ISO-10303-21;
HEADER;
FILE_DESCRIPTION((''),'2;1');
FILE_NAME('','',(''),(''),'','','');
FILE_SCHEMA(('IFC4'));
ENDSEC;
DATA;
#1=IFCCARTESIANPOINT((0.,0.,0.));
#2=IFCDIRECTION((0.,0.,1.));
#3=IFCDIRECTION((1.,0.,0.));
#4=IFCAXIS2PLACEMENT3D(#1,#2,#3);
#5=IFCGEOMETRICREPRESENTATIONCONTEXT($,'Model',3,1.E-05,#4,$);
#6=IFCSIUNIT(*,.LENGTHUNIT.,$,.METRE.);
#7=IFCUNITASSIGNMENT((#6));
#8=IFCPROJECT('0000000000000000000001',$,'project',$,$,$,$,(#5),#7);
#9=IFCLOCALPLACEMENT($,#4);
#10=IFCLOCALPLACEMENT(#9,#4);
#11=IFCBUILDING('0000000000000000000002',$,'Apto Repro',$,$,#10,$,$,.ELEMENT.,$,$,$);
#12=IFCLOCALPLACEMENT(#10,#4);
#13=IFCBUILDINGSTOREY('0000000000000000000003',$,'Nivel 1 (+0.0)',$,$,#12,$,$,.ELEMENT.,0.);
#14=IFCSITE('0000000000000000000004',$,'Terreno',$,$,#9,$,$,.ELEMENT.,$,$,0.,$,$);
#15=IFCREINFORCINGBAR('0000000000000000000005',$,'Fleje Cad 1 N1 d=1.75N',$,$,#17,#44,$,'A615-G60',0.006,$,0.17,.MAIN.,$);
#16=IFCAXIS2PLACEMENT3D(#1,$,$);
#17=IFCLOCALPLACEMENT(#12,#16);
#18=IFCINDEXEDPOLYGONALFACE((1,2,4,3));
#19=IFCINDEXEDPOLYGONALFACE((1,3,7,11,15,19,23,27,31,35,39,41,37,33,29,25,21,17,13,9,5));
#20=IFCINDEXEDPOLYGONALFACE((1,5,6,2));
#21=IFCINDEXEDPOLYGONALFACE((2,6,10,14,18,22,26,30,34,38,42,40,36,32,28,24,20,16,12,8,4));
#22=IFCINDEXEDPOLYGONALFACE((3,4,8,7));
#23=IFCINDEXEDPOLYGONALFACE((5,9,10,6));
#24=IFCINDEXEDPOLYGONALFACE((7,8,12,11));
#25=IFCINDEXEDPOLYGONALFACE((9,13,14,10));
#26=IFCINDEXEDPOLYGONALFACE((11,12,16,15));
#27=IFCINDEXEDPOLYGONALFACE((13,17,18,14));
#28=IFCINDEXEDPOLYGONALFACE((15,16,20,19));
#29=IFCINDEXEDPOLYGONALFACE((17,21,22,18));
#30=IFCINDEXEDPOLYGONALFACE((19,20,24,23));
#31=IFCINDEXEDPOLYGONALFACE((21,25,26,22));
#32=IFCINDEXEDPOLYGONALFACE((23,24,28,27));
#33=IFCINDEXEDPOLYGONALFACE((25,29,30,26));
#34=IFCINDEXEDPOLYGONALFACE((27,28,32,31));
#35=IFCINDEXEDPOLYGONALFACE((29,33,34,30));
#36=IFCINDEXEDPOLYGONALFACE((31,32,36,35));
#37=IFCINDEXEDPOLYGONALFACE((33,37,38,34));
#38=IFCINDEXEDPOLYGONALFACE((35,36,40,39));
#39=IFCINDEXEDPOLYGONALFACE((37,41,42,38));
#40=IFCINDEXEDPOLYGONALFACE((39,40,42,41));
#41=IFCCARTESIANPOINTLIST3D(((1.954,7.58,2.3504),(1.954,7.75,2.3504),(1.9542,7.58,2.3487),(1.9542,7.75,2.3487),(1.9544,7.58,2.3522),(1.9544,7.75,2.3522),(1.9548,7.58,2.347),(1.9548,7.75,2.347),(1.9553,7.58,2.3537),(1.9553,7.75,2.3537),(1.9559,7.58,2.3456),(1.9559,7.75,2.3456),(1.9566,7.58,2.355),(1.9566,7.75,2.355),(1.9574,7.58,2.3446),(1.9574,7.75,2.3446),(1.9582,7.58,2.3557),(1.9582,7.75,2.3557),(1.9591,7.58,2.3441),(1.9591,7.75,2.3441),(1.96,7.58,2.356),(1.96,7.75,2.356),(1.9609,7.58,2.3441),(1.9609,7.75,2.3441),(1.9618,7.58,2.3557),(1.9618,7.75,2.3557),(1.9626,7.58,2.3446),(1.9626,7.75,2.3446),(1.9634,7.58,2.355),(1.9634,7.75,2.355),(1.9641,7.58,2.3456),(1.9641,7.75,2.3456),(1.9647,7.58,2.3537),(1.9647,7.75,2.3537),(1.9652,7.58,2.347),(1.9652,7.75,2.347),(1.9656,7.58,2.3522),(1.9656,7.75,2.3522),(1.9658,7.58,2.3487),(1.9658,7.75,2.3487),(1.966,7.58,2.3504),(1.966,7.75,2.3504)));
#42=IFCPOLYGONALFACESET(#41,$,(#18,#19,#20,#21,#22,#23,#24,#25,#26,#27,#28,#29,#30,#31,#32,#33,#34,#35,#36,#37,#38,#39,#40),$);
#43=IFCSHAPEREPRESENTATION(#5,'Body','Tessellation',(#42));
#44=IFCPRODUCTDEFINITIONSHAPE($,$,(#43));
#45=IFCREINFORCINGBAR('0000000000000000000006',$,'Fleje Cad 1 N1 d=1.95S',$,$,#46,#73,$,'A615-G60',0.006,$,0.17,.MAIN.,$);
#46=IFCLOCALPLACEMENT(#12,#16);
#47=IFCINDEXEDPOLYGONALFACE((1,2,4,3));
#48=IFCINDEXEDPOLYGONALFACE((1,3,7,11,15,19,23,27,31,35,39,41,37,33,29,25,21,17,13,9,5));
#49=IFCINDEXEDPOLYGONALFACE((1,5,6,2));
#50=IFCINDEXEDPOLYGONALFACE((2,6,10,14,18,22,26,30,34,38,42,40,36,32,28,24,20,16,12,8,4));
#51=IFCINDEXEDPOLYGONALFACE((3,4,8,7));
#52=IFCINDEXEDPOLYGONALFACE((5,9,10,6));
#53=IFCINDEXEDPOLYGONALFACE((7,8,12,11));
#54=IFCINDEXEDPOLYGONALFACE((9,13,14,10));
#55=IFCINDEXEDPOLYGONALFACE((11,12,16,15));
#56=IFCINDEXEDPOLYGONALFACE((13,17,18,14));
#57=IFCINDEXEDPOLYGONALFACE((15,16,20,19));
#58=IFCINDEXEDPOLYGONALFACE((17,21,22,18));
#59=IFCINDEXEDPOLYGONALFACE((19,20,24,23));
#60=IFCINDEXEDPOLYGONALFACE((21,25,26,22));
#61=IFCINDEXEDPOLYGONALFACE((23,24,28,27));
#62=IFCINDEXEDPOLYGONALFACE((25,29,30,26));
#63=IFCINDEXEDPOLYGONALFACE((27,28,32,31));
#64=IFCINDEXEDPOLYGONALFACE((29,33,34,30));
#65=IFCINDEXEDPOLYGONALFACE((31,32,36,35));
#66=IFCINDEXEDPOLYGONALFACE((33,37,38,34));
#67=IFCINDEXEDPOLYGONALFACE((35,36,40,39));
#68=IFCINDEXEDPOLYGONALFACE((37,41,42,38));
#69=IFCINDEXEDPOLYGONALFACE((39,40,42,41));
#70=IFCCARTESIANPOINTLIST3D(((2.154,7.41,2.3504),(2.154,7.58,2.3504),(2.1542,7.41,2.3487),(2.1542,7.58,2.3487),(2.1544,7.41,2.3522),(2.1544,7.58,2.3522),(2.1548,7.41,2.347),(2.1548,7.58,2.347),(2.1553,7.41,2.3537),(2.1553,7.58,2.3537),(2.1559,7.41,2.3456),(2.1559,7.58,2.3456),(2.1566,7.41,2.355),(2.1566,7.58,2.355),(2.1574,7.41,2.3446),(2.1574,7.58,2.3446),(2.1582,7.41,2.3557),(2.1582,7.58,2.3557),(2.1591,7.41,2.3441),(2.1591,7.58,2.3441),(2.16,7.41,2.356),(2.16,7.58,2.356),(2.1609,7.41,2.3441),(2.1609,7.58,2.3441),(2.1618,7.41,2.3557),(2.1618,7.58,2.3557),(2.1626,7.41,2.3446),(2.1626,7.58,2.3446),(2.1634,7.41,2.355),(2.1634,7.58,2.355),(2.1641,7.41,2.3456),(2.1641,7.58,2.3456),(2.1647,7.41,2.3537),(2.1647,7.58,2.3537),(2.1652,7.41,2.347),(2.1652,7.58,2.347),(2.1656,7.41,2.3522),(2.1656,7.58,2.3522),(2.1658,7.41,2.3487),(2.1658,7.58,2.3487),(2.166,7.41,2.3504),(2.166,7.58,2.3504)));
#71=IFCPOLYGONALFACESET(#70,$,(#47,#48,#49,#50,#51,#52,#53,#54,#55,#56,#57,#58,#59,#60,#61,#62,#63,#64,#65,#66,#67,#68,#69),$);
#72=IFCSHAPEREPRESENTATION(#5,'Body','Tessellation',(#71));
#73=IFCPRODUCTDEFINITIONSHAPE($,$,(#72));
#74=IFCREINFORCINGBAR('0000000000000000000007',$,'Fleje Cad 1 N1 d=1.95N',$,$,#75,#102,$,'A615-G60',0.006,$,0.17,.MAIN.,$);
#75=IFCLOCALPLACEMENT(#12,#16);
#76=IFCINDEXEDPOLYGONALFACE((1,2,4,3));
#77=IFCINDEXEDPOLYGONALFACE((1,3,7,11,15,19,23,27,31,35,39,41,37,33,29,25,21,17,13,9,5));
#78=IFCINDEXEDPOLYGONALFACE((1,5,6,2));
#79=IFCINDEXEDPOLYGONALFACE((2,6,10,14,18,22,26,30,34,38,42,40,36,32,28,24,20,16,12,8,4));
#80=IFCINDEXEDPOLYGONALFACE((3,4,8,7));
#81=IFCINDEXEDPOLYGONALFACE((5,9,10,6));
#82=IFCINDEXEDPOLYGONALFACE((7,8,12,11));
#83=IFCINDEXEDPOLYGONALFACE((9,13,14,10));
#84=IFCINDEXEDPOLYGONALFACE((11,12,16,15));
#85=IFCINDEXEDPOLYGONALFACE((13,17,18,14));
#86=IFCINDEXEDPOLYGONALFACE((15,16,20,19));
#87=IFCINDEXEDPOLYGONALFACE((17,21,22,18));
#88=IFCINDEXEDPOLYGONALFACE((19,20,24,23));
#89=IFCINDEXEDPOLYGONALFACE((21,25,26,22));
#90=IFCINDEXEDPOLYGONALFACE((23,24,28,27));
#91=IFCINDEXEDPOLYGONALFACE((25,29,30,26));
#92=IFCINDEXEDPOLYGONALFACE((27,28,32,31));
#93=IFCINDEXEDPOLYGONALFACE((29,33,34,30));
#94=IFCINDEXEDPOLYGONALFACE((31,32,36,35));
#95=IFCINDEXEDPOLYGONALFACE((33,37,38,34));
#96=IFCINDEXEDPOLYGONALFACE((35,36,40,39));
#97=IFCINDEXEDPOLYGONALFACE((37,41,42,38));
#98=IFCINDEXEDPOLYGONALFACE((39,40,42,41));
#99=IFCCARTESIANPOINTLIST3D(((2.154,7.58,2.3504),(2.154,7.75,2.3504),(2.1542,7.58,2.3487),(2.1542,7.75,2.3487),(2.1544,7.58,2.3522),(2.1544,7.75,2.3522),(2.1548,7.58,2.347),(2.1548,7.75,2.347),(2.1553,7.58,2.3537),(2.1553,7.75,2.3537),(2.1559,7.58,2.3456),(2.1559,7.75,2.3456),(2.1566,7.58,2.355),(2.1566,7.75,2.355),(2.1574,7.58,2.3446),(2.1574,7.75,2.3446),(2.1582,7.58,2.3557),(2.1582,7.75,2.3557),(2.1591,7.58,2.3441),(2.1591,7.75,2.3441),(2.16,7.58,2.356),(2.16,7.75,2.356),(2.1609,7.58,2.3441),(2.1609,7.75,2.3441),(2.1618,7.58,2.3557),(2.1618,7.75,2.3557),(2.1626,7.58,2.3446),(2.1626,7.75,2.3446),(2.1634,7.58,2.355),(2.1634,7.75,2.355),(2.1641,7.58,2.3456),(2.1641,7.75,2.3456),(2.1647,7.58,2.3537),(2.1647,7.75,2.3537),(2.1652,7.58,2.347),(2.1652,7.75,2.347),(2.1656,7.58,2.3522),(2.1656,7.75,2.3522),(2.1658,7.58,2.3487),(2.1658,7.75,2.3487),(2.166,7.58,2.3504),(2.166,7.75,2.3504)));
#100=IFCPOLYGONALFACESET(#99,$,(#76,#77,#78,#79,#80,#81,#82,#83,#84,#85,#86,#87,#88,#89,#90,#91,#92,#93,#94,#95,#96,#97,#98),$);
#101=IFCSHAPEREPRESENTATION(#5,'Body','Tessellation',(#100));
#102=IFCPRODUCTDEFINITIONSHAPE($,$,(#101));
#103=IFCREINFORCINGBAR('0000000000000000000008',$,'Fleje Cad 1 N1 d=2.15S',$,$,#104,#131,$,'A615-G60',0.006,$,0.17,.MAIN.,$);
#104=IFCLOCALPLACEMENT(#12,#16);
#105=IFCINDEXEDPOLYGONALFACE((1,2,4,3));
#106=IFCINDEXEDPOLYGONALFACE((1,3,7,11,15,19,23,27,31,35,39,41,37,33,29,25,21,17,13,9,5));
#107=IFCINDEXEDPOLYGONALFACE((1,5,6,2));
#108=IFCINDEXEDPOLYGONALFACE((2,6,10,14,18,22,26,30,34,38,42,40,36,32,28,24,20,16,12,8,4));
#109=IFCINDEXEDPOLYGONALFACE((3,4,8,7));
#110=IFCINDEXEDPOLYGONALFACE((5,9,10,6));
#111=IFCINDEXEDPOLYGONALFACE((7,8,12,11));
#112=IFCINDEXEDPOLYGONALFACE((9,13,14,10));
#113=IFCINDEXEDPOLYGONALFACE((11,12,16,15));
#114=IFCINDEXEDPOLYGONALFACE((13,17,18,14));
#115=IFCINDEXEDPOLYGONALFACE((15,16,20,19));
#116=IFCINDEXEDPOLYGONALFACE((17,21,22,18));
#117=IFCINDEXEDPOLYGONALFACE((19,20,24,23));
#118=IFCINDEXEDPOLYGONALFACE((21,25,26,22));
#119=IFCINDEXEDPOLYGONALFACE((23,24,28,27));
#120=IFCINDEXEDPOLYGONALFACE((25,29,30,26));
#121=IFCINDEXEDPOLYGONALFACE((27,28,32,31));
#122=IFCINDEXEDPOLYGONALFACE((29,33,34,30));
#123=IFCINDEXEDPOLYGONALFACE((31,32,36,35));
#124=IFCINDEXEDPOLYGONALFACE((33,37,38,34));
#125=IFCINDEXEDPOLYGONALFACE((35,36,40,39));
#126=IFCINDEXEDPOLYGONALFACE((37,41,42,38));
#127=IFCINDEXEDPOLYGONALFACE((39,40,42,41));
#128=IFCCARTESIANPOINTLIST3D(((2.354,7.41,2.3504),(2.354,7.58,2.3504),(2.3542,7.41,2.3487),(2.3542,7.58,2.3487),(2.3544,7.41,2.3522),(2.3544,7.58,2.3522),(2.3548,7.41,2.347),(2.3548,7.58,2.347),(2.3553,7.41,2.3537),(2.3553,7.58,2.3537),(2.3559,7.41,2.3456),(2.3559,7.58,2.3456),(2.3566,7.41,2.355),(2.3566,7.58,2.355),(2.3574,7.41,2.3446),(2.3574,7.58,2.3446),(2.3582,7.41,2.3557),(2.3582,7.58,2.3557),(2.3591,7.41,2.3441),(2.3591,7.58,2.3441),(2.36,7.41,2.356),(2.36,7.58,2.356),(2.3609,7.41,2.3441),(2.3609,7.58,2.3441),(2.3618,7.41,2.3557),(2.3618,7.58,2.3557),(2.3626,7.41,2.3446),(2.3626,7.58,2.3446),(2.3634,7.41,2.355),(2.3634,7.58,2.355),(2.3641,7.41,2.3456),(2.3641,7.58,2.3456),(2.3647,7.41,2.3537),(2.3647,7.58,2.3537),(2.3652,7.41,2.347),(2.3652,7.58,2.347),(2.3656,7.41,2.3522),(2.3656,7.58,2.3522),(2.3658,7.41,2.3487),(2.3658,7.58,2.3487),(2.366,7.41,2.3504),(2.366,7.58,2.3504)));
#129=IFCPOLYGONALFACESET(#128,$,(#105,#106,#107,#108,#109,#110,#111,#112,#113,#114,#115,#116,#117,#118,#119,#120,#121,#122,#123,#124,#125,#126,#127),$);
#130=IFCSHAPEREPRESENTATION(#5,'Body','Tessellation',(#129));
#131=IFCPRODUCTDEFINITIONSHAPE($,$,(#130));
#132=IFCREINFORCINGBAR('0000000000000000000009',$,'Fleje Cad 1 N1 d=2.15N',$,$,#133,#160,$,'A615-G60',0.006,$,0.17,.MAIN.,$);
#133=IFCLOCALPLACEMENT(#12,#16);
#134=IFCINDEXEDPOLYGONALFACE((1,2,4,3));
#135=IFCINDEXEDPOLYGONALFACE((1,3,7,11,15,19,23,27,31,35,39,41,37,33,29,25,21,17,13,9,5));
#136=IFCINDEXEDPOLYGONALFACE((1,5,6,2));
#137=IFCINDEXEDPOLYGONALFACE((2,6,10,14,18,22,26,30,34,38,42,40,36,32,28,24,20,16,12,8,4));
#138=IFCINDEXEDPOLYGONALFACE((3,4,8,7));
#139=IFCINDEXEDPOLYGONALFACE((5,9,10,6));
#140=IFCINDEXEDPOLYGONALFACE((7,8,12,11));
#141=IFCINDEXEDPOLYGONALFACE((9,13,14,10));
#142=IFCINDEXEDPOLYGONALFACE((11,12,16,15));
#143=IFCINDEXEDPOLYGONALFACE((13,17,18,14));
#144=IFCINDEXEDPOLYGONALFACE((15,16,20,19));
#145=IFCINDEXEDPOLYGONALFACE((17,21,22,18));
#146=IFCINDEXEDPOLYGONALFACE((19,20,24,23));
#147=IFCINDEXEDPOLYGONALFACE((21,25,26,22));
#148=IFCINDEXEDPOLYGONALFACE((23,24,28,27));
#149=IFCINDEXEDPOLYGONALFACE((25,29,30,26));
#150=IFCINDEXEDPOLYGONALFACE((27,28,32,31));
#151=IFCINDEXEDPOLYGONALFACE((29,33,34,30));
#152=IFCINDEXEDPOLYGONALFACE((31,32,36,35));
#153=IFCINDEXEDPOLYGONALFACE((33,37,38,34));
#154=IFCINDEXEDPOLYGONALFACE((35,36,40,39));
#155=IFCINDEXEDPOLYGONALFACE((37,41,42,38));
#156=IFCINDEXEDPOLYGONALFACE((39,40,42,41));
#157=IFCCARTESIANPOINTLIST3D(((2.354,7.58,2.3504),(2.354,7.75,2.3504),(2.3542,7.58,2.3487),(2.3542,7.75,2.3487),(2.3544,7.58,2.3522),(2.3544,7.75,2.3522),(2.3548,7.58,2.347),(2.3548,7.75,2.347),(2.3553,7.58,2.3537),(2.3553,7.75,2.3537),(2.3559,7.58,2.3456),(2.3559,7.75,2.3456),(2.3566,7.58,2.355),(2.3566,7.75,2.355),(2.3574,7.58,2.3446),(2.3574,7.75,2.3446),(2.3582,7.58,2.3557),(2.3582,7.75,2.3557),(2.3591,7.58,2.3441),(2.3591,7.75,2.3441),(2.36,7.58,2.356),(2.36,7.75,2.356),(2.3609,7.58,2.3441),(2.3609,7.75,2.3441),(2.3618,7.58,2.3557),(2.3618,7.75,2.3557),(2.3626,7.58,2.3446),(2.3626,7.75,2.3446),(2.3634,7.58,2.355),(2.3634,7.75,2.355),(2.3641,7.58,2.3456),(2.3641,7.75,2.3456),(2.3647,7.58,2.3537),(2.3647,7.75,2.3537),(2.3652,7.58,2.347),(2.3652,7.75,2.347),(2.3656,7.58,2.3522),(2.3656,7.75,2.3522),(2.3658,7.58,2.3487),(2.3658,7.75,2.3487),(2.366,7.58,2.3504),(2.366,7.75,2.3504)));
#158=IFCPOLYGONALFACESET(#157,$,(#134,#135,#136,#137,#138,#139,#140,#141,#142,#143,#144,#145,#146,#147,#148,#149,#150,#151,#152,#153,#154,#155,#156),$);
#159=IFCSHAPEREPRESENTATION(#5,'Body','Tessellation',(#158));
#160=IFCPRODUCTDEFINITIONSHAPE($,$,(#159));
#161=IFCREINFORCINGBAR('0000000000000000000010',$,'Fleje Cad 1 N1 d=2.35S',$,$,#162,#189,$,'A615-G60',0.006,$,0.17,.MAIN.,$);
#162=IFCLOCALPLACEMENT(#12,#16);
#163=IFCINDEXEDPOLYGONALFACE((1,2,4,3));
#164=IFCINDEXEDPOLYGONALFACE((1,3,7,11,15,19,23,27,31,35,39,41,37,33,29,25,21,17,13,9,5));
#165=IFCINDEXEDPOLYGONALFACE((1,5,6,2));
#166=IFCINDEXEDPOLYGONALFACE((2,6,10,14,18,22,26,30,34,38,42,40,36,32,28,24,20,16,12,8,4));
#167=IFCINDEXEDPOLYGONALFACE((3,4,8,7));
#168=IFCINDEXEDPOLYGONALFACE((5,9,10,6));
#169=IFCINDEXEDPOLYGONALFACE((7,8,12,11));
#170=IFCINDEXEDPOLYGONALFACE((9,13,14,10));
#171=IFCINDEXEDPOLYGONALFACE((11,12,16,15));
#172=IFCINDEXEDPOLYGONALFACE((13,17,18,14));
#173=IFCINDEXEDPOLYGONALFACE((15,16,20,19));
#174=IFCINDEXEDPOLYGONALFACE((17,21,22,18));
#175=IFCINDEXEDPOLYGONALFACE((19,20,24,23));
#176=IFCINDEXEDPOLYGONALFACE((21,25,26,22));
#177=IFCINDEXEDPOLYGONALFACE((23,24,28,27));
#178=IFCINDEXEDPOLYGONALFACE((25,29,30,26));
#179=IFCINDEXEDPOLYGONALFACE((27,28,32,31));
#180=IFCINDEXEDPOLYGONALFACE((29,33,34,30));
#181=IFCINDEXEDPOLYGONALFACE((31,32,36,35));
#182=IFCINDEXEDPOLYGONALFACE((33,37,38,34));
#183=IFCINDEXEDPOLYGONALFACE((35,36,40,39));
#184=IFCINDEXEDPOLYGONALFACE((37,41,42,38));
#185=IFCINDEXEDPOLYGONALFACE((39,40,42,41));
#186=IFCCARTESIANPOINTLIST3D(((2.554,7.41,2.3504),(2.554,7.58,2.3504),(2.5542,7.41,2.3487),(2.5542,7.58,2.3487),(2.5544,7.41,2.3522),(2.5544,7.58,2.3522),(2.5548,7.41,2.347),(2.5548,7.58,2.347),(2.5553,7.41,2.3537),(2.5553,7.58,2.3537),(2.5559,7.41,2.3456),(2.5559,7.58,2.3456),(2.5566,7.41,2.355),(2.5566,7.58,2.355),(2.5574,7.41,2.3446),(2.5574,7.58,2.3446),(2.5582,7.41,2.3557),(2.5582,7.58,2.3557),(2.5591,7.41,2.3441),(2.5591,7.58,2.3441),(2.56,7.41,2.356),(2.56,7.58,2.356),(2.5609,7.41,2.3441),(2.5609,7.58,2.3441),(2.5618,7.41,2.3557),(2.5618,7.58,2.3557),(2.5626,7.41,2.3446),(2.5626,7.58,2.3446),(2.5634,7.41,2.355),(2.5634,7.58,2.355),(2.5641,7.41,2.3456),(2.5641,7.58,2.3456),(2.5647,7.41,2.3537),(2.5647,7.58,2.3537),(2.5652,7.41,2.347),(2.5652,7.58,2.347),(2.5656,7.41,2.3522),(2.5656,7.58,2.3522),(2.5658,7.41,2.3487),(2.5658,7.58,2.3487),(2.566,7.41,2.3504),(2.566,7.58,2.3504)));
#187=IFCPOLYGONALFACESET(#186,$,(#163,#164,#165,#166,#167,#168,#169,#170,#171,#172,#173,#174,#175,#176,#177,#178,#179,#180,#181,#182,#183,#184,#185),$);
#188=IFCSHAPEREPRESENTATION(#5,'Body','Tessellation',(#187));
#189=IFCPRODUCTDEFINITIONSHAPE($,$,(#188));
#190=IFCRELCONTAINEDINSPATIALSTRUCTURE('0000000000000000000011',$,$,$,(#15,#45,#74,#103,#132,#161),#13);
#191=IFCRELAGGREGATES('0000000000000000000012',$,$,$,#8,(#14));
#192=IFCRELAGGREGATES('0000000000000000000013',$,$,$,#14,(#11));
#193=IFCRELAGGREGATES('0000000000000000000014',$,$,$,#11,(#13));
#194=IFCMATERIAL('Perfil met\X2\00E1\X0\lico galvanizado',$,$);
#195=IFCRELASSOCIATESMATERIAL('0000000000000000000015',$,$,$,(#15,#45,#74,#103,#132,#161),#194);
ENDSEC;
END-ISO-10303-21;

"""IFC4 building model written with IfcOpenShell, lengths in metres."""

from ifc_helpers import new_model, si_unit, frame, origin_with_axes, origin_2d_with_axis, place, context, project, spatial, circle, extrude, material, element, save


model = new_model("IFC4")

# Units and contexts
model_context = context("Model", 3, precision=1e-05, world=origin_with_axes())
ifc_project = project(units=[si_unit("LENGTHUNIT", "METRE")], contexts=[model_context])

# Site, building, storey
site_placement = place(None, origin_with_axes())
site = spatial("IfcSite", under=ifc_project, at=site_placement, Name="Terreno", CompositionType="ELEMENT", RefElevation=0.0)
building_placement = place(site_placement, origin_with_axes())
building = spatial("IfcBuilding", under=site, at=building_placement, Name="Apto Repro", CompositionType="ELEMENT")
storey_placement = place(building_placement, origin_with_axes())
storey = spatial("IfcBuildingStorey", under=building, at=storey_placement, Name="Nivel 1 (+0.0)", CompositionType="ELEMENT", Elevation=0.0)

# Reinforcing bars
ifc_material = material(Name="Perfil metálico galvanizado")
reinforcing_bar_1_placement = place(storey_placement, origin_with_axes())
element("IfcReinforcingBar", 1, at=reinforcing_bar_1_placement, inside=storey, material=ifc_material, Name="Fleje Cad 1 N1 d=1.75N", SteelGrade="A615-G60", BarLength=0.17, NominalDiameter=0.006, PredefinedType="MAIN", context=model_context, shape_type="SweptSolid", body=[
    extrude(circle(Radius=0.006, at=origin_2d_with_axis()), frame((1.96, 7.58, 2.35), z_axis=(0.0, 1.0, 0.0), x_axis=(0.0, 0.0, 1.0)), (0.0, 0.0, 1.0), 0.17),
])
reinforcing_bar_2_placement = place(storey_placement, origin_with_axes())
element("IfcReinforcingBar", 2, at=reinforcing_bar_2_placement, inside=storey, material=ifc_material, Name="Fleje Cad 1 N1 d=1.95S", SteelGrade="A615-G60", BarLength=0.17, NominalDiameter=0.006, PredefinedType="MAIN", context=model_context, shape_type="SweptSolid", body=[
    extrude(circle(Radius=0.006, at=origin_2d_with_axis()), frame((2.16, 7.41, 2.35), z_axis=(0.0, 1.0, 0.0), x_axis=(0.0, 0.0, 1.0)), (0.0, 0.0, 1.0), 0.17),
])
reinforcing_bar_3_placement = place(storey_placement, origin_with_axes())
element("IfcReinforcingBar", 3, at=reinforcing_bar_3_placement, inside=storey, material=ifc_material, Name="Fleje Cad 1 N1 d=1.95N", SteelGrade="A615-G60", BarLength=0.17, NominalDiameter=0.006, PredefinedType="MAIN", context=model_context, shape_type="SweptSolid", body=[
    extrude(circle(Radius=0.006, at=origin_2d_with_axis()), frame((2.16, 7.58, 2.35), z_axis=(0.0, 1.0, 0.0), x_axis=(0.0, 0.0, 1.0)), (0.0, 0.0, 1.0), 0.17),
])
reinforcing_bar_4_placement = place(storey_placement, origin_with_axes())
element("IfcReinforcingBar", 4, at=reinforcing_bar_4_placement, inside=storey, material=ifc_material, Name="Fleje Cad 1 N1 d=2.15S", SteelGrade="A615-G60", BarLength=0.17, NominalDiameter=0.006, PredefinedType="MAIN", context=model_context, shape_type="SweptSolid", body=[
    extrude(circle(Radius=0.006, at=origin_2d_with_axis()), frame((2.36, 7.41, 2.35), z_axis=(0.0, 1.0, 0.0), x_axis=(0.0, 0.0, 1.0)), (0.0, 0.0, 1.0), 0.17),
])
reinforcing_bar_5_placement = place(storey_placement, origin_with_axes())
element("IfcReinforcingBar", 5, at=reinforcing_bar_5_placement, inside=storey, material=ifc_material, Name="Fleje Cad 1 N1 d=2.15N", SteelGrade="A615-G60", BarLength=0.17, NominalDiameter=0.006, PredefinedType="MAIN", context=model_context, shape_type="SweptSolid", body=[
    extrude(circle(Radius=0.006, at=origin_2d_with_axis()), frame((2.36, 7.58, 2.35), z_axis=(0.0, 1.0, 0.0), x_axis=(0.0, 0.0, 1.0)), (0.0, 0.0, 1.0), 0.17),
])
reinforcing_bar_6_placement = place(storey_placement, origin_with_axes())
element("IfcReinforcingBar", 6, at=reinforcing_bar_6_placement, inside=storey, material=ifc_material, Name="Fleje Cad 1 N1 d=2.35S", SteelGrade="A615-G60", BarLength=0.17, NominalDiameter=0.006, PredefinedType="MAIN", context=model_context, shape_type="SweptSolid", body=[
    extrude(circle(Radius=0.006, at=origin_2d_with_axis()), frame((2.56, 7.41, 2.35), z_axis=(0.0, 1.0, 0.0), x_axis=(0.0, 0.0, 1.0)), (0.0, 0.0, 1.0), 0.17),
])

save(model, "model.ifc")
